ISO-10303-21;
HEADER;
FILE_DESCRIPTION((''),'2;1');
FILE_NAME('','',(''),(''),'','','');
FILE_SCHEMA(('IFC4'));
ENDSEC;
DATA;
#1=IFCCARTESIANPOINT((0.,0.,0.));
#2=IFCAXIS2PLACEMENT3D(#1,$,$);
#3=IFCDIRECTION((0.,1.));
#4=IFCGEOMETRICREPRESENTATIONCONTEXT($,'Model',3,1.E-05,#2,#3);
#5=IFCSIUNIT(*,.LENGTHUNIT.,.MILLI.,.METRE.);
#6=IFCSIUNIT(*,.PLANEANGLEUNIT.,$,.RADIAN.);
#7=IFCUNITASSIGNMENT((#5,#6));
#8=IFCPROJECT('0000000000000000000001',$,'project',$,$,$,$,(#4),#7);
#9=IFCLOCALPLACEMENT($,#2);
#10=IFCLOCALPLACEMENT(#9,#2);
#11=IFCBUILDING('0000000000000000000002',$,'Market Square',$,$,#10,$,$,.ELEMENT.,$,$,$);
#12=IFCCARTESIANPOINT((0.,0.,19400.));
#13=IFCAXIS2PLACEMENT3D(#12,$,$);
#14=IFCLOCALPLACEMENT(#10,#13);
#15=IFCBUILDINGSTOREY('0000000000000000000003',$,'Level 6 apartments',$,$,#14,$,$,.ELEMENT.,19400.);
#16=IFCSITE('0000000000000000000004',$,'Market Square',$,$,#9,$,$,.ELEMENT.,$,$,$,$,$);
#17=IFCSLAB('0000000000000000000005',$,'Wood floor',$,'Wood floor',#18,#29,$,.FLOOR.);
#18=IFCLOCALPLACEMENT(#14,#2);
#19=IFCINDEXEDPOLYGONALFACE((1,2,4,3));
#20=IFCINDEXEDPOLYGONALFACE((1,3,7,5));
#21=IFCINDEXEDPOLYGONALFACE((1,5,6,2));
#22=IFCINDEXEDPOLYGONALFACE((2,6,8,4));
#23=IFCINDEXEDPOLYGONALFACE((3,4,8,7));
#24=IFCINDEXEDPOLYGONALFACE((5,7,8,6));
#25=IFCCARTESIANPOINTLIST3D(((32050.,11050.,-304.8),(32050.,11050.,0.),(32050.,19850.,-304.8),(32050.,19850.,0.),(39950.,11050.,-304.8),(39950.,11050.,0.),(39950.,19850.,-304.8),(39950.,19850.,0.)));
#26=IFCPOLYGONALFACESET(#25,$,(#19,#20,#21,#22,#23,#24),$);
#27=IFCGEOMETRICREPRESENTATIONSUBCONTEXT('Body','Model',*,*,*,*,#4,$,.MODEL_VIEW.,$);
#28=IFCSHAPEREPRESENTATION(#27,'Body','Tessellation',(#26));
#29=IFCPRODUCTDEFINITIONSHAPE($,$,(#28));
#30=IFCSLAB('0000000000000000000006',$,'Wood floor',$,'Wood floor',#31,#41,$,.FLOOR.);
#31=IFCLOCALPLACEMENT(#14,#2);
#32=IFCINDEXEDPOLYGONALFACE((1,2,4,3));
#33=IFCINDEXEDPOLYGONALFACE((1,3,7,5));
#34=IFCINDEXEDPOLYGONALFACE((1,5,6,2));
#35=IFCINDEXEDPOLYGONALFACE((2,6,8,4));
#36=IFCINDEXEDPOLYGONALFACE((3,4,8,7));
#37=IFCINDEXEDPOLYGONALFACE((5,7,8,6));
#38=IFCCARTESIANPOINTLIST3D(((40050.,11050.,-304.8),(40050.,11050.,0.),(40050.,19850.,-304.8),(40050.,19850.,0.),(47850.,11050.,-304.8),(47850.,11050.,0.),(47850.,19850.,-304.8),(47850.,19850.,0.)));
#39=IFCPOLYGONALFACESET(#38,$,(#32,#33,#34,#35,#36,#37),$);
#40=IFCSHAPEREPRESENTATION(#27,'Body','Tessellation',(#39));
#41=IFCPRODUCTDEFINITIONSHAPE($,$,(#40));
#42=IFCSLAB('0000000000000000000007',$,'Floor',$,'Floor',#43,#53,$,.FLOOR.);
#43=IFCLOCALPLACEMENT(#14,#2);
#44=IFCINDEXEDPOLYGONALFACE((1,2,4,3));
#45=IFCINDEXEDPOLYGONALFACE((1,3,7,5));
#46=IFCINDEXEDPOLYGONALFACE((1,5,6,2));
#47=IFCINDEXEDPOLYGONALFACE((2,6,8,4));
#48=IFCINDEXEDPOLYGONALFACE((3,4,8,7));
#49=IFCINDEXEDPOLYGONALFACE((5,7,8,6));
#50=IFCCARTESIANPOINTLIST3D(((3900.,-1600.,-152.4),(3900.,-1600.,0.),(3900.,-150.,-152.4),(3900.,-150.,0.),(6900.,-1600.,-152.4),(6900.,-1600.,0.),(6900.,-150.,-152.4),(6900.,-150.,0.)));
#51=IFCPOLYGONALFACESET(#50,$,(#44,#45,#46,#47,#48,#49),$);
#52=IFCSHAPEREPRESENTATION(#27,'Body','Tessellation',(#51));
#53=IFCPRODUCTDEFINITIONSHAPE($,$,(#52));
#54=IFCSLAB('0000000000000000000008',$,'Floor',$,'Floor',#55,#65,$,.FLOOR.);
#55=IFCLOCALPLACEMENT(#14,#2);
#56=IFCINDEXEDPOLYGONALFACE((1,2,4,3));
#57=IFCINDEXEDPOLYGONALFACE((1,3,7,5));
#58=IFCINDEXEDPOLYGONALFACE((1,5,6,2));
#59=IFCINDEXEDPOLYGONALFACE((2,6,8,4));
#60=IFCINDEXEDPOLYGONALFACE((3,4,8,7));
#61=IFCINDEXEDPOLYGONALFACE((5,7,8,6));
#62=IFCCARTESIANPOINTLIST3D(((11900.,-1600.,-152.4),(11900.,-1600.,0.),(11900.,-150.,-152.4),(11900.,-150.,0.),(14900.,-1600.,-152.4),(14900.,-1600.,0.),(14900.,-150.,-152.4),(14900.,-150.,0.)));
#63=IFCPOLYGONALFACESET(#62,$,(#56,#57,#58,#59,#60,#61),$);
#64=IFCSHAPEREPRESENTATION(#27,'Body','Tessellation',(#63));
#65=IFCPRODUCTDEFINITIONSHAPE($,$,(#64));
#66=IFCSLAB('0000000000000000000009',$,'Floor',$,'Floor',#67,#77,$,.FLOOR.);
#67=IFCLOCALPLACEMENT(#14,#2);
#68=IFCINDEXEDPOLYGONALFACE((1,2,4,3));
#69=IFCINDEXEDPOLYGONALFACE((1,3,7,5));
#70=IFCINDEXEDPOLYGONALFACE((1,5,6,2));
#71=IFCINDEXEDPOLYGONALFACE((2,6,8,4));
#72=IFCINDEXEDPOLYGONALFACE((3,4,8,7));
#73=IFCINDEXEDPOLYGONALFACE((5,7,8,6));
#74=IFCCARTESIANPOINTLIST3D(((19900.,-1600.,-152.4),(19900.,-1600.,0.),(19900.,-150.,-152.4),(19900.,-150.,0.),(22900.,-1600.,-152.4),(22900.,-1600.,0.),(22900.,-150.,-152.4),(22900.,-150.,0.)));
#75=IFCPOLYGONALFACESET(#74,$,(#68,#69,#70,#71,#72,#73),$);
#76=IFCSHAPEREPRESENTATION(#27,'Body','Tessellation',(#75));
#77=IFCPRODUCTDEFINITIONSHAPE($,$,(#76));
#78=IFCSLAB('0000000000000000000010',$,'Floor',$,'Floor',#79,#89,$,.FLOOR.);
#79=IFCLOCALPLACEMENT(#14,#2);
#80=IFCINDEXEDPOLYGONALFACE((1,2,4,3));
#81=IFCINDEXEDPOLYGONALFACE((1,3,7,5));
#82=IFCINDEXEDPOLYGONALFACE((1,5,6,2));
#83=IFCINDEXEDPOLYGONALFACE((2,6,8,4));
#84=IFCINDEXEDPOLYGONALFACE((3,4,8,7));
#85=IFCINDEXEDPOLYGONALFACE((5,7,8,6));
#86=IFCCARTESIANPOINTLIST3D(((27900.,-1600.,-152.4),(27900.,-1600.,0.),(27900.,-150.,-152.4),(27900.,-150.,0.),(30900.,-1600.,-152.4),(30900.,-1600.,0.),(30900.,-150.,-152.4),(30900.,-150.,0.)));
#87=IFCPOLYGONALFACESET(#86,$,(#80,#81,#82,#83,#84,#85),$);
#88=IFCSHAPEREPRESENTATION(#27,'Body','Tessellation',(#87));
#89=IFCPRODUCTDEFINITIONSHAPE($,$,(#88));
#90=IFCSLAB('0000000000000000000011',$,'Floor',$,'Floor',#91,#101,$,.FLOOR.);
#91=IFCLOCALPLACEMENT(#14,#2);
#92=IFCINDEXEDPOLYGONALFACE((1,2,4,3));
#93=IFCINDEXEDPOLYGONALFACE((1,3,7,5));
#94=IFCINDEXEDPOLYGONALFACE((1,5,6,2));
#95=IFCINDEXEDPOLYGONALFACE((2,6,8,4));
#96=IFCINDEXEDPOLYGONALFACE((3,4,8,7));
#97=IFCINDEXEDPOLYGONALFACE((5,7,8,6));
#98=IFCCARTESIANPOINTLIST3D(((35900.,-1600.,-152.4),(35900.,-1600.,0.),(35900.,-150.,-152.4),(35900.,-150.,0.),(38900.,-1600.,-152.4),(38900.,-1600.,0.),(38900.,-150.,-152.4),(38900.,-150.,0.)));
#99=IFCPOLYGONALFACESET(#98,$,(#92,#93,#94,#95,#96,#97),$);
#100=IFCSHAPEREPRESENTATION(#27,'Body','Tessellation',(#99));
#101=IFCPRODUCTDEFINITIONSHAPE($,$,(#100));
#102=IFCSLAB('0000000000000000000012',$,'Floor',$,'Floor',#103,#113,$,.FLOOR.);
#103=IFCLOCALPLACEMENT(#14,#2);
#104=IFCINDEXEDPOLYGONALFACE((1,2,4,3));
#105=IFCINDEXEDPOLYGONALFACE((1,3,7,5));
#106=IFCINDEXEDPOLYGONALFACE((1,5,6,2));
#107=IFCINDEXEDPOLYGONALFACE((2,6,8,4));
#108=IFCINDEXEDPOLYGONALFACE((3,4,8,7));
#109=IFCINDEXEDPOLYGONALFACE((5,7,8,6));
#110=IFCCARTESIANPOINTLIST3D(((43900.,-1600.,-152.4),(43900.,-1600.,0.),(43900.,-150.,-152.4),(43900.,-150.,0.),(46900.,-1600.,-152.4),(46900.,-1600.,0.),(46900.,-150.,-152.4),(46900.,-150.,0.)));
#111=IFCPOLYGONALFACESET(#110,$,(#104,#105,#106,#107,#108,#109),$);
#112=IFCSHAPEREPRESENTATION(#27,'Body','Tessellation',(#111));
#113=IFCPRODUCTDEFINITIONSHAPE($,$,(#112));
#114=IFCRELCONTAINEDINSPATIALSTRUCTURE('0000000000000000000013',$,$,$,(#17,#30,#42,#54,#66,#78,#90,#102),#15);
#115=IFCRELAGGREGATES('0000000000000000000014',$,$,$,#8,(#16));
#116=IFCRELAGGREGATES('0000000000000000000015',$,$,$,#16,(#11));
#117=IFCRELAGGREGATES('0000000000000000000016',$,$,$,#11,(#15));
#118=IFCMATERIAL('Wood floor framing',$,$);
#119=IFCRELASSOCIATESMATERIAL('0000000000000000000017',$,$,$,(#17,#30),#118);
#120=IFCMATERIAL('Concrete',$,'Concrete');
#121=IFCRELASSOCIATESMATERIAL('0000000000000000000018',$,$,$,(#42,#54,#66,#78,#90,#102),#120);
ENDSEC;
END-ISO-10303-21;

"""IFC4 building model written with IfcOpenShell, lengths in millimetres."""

from ifc_helpers import new_model, si_unit, direction, frame, origin, origin_with_axes, place, context, subcontext, project, spatial, polyline, outline, extrude, material, element, save


model = new_model("IFC4")

# Units and contexts
model_context = context("Model", 3, precision=1e-05, world=origin(), true_north=direction((0.0, 1.0)))
body_context = subcontext(model_context, "Body", "Model", "MODEL_VIEW")
ifc_project = project(units=[si_unit("LENGTHUNIT", "METRE", prefix="MILLI"), si_unit("PLANEANGLEUNIT", "RADIAN")], contexts=[model_context])

# Site, building, storey
site_placement = place(None, origin())
site = spatial("IfcSite", under=ifc_project, at=site_placement, Name="Market Square", CompositionType="ELEMENT")
building_placement = place(site_placement, origin())
building = spatial("IfcBuilding", under=site, at=building_placement, Name="Market Square", CompositionType="ELEMENT")
storey_placement = place(building_placement, frame((0.0, 0.0, 19400.0)))
storey = spatial("IfcBuildingStorey", under=building, at=storey_placement, Name="Level 6 apartments", CompositionType="ELEMENT", Elevation=19400.0)

# Slabs
ifc_material_1 = material(Name="Wood floor framing")
slab_1_placement = place(storey_placement, origin_with_axes())
element("IfcSlab", 1, at=slab_1_placement, inside=storey, material=ifc_material_1, Name="Wood floor", ObjectType="Wood floor", PredefinedType="FLOOR", context=body_context, shape_type="SweptSolid", body=[
    extrude(outline(polyline([(39950.0, 19850.0), (32050.0, 19850.0), (32050.0, 11050.0), (39950.0, 11050.0), (39950.0, 19850.0)])), frame((0.0, 0.0, -304.8)), (0.0, 0.0, 1.0), 304.8),
])
slab_2_placement = place(storey_placement, origin_with_axes())
element("IfcSlab", 2, at=slab_2_placement, inside=storey, material=ifc_material_1, Name="Wood floor", ObjectType="Wood floor", PredefinedType="FLOOR", context=body_context, shape_type="SweptSolid", body=[
    extrude(outline(polyline([(47850.0, 11050.0), (47850.0, 19850.0), (40050.0, 19850.0), (40050.0, 11050.0), (47850.0, 11050.0)])), frame((0.0, 0.0, -304.8)), (0.0, 0.0, 1.0), 304.8),
])
ifc_material_2 = material(Name="Concrete", Category="Concrete")
slab_3_placement = place(storey_placement, origin_with_axes())
element("IfcSlab", 3, at=slab_3_placement, inside=storey, material=ifc_material_2, Name="Floor", ObjectType="Floor", PredefinedType="FLOOR", context=body_context, shape_type="SweptSolid", body=[
    extrude(outline(polyline([(3900.0, -1600.0), (6900.0, -1600.0), (6900.0, -150.0), (3900.0, -150.0), (3900.0, -1600.0)])), frame((0.0, 0.0, -152.4)), (0.0, 0.0, 1.0), 152.4),
])
slab_4_placement = place(storey_placement, origin_with_axes())
element("IfcSlab", 4, at=slab_4_placement, inside=storey, material=ifc_material_2, Name="Floor", ObjectType="Floor", PredefinedType="FLOOR", context=body_context, shape_type="SweptSolid", body=[
    extrude(outline(polyline([(11900.0, -1600.0), (14900.0, -1600.0), (14900.0, -150.0), (11900.0, -150.0), (11900.0, -1600.0)])), frame((0.0, 0.0, -152.4)), (0.0, 0.0, 1.0), 152.4),
])
slab_5_placement = place(storey_placement, origin_with_axes())
element("IfcSlab", 5, at=slab_5_placement, inside=storey, material=ifc_material_2, Name="Floor", ObjectType="Floor", PredefinedType="FLOOR", context=body_context, shape_type="SweptSolid", body=[
    extrude(outline(polyline([(19900.0, -1600.0), (22900.0, -1600.0), (22900.0, -150.0), (19900.0, -150.0), (19900.0, -1600.0)])), frame((0.0, 0.0, -152.4)), (0.0, 0.0, 1.0), 152.4),
])
slab_6_placement = place(storey_placement, origin_with_axes())
element("IfcSlab", 6, at=slab_6_placement, inside=storey, material=ifc_material_2, Name="Floor", ObjectType="Floor", PredefinedType="FLOOR", context=body_context, shape_type="SweptSolid", body=[
    extrude(outline(polyline([(27900.0, -1600.0), (30900.0, -1600.0), (30900.0, -150.0), (27900.0, -150.0), (27900.0, -1600.0)])), frame((0.0, 0.0, -152.4)), (0.0, 0.0, 1.0), 152.4),
])
slab_7_placement = place(storey_placement, origin_with_axes())
element("IfcSlab", 7, at=slab_7_placement, inside=storey, material=ifc_material_2, Name="Floor", ObjectType="Floor", PredefinedType="FLOOR", context=body_context, shape_type="SweptSolid", body=[
    extrude(outline(polyline([(35900.0, -1600.0), (38900.0, -1600.0), (38900.0, -150.0), (35900.0, -150.0), (35900.0, -1600.0)])), frame((0.0, 0.0, -152.4)), (0.0, 0.0, 1.0), 152.4),
])
slab_8_placement = place(storey_placement, origin_with_axes())
element("IfcSlab", 8, at=slab_8_placement, inside=storey, material=ifc_material_2, Name="Floor", ObjectType="Floor", PredefinedType="FLOOR", context=body_context, shape_type="SweptSolid", body=[
    extrude(outline(polyline([(43900.0, -1600.0), (46900.0, -1600.0), (46900.0, -150.0), (43900.0, -150.0), (43900.0, -1600.0)])), frame((0.0, 0.0, -152.4)), (0.0, 0.0, 1.0), 152.4),
])

save(model, "model.ifc")
